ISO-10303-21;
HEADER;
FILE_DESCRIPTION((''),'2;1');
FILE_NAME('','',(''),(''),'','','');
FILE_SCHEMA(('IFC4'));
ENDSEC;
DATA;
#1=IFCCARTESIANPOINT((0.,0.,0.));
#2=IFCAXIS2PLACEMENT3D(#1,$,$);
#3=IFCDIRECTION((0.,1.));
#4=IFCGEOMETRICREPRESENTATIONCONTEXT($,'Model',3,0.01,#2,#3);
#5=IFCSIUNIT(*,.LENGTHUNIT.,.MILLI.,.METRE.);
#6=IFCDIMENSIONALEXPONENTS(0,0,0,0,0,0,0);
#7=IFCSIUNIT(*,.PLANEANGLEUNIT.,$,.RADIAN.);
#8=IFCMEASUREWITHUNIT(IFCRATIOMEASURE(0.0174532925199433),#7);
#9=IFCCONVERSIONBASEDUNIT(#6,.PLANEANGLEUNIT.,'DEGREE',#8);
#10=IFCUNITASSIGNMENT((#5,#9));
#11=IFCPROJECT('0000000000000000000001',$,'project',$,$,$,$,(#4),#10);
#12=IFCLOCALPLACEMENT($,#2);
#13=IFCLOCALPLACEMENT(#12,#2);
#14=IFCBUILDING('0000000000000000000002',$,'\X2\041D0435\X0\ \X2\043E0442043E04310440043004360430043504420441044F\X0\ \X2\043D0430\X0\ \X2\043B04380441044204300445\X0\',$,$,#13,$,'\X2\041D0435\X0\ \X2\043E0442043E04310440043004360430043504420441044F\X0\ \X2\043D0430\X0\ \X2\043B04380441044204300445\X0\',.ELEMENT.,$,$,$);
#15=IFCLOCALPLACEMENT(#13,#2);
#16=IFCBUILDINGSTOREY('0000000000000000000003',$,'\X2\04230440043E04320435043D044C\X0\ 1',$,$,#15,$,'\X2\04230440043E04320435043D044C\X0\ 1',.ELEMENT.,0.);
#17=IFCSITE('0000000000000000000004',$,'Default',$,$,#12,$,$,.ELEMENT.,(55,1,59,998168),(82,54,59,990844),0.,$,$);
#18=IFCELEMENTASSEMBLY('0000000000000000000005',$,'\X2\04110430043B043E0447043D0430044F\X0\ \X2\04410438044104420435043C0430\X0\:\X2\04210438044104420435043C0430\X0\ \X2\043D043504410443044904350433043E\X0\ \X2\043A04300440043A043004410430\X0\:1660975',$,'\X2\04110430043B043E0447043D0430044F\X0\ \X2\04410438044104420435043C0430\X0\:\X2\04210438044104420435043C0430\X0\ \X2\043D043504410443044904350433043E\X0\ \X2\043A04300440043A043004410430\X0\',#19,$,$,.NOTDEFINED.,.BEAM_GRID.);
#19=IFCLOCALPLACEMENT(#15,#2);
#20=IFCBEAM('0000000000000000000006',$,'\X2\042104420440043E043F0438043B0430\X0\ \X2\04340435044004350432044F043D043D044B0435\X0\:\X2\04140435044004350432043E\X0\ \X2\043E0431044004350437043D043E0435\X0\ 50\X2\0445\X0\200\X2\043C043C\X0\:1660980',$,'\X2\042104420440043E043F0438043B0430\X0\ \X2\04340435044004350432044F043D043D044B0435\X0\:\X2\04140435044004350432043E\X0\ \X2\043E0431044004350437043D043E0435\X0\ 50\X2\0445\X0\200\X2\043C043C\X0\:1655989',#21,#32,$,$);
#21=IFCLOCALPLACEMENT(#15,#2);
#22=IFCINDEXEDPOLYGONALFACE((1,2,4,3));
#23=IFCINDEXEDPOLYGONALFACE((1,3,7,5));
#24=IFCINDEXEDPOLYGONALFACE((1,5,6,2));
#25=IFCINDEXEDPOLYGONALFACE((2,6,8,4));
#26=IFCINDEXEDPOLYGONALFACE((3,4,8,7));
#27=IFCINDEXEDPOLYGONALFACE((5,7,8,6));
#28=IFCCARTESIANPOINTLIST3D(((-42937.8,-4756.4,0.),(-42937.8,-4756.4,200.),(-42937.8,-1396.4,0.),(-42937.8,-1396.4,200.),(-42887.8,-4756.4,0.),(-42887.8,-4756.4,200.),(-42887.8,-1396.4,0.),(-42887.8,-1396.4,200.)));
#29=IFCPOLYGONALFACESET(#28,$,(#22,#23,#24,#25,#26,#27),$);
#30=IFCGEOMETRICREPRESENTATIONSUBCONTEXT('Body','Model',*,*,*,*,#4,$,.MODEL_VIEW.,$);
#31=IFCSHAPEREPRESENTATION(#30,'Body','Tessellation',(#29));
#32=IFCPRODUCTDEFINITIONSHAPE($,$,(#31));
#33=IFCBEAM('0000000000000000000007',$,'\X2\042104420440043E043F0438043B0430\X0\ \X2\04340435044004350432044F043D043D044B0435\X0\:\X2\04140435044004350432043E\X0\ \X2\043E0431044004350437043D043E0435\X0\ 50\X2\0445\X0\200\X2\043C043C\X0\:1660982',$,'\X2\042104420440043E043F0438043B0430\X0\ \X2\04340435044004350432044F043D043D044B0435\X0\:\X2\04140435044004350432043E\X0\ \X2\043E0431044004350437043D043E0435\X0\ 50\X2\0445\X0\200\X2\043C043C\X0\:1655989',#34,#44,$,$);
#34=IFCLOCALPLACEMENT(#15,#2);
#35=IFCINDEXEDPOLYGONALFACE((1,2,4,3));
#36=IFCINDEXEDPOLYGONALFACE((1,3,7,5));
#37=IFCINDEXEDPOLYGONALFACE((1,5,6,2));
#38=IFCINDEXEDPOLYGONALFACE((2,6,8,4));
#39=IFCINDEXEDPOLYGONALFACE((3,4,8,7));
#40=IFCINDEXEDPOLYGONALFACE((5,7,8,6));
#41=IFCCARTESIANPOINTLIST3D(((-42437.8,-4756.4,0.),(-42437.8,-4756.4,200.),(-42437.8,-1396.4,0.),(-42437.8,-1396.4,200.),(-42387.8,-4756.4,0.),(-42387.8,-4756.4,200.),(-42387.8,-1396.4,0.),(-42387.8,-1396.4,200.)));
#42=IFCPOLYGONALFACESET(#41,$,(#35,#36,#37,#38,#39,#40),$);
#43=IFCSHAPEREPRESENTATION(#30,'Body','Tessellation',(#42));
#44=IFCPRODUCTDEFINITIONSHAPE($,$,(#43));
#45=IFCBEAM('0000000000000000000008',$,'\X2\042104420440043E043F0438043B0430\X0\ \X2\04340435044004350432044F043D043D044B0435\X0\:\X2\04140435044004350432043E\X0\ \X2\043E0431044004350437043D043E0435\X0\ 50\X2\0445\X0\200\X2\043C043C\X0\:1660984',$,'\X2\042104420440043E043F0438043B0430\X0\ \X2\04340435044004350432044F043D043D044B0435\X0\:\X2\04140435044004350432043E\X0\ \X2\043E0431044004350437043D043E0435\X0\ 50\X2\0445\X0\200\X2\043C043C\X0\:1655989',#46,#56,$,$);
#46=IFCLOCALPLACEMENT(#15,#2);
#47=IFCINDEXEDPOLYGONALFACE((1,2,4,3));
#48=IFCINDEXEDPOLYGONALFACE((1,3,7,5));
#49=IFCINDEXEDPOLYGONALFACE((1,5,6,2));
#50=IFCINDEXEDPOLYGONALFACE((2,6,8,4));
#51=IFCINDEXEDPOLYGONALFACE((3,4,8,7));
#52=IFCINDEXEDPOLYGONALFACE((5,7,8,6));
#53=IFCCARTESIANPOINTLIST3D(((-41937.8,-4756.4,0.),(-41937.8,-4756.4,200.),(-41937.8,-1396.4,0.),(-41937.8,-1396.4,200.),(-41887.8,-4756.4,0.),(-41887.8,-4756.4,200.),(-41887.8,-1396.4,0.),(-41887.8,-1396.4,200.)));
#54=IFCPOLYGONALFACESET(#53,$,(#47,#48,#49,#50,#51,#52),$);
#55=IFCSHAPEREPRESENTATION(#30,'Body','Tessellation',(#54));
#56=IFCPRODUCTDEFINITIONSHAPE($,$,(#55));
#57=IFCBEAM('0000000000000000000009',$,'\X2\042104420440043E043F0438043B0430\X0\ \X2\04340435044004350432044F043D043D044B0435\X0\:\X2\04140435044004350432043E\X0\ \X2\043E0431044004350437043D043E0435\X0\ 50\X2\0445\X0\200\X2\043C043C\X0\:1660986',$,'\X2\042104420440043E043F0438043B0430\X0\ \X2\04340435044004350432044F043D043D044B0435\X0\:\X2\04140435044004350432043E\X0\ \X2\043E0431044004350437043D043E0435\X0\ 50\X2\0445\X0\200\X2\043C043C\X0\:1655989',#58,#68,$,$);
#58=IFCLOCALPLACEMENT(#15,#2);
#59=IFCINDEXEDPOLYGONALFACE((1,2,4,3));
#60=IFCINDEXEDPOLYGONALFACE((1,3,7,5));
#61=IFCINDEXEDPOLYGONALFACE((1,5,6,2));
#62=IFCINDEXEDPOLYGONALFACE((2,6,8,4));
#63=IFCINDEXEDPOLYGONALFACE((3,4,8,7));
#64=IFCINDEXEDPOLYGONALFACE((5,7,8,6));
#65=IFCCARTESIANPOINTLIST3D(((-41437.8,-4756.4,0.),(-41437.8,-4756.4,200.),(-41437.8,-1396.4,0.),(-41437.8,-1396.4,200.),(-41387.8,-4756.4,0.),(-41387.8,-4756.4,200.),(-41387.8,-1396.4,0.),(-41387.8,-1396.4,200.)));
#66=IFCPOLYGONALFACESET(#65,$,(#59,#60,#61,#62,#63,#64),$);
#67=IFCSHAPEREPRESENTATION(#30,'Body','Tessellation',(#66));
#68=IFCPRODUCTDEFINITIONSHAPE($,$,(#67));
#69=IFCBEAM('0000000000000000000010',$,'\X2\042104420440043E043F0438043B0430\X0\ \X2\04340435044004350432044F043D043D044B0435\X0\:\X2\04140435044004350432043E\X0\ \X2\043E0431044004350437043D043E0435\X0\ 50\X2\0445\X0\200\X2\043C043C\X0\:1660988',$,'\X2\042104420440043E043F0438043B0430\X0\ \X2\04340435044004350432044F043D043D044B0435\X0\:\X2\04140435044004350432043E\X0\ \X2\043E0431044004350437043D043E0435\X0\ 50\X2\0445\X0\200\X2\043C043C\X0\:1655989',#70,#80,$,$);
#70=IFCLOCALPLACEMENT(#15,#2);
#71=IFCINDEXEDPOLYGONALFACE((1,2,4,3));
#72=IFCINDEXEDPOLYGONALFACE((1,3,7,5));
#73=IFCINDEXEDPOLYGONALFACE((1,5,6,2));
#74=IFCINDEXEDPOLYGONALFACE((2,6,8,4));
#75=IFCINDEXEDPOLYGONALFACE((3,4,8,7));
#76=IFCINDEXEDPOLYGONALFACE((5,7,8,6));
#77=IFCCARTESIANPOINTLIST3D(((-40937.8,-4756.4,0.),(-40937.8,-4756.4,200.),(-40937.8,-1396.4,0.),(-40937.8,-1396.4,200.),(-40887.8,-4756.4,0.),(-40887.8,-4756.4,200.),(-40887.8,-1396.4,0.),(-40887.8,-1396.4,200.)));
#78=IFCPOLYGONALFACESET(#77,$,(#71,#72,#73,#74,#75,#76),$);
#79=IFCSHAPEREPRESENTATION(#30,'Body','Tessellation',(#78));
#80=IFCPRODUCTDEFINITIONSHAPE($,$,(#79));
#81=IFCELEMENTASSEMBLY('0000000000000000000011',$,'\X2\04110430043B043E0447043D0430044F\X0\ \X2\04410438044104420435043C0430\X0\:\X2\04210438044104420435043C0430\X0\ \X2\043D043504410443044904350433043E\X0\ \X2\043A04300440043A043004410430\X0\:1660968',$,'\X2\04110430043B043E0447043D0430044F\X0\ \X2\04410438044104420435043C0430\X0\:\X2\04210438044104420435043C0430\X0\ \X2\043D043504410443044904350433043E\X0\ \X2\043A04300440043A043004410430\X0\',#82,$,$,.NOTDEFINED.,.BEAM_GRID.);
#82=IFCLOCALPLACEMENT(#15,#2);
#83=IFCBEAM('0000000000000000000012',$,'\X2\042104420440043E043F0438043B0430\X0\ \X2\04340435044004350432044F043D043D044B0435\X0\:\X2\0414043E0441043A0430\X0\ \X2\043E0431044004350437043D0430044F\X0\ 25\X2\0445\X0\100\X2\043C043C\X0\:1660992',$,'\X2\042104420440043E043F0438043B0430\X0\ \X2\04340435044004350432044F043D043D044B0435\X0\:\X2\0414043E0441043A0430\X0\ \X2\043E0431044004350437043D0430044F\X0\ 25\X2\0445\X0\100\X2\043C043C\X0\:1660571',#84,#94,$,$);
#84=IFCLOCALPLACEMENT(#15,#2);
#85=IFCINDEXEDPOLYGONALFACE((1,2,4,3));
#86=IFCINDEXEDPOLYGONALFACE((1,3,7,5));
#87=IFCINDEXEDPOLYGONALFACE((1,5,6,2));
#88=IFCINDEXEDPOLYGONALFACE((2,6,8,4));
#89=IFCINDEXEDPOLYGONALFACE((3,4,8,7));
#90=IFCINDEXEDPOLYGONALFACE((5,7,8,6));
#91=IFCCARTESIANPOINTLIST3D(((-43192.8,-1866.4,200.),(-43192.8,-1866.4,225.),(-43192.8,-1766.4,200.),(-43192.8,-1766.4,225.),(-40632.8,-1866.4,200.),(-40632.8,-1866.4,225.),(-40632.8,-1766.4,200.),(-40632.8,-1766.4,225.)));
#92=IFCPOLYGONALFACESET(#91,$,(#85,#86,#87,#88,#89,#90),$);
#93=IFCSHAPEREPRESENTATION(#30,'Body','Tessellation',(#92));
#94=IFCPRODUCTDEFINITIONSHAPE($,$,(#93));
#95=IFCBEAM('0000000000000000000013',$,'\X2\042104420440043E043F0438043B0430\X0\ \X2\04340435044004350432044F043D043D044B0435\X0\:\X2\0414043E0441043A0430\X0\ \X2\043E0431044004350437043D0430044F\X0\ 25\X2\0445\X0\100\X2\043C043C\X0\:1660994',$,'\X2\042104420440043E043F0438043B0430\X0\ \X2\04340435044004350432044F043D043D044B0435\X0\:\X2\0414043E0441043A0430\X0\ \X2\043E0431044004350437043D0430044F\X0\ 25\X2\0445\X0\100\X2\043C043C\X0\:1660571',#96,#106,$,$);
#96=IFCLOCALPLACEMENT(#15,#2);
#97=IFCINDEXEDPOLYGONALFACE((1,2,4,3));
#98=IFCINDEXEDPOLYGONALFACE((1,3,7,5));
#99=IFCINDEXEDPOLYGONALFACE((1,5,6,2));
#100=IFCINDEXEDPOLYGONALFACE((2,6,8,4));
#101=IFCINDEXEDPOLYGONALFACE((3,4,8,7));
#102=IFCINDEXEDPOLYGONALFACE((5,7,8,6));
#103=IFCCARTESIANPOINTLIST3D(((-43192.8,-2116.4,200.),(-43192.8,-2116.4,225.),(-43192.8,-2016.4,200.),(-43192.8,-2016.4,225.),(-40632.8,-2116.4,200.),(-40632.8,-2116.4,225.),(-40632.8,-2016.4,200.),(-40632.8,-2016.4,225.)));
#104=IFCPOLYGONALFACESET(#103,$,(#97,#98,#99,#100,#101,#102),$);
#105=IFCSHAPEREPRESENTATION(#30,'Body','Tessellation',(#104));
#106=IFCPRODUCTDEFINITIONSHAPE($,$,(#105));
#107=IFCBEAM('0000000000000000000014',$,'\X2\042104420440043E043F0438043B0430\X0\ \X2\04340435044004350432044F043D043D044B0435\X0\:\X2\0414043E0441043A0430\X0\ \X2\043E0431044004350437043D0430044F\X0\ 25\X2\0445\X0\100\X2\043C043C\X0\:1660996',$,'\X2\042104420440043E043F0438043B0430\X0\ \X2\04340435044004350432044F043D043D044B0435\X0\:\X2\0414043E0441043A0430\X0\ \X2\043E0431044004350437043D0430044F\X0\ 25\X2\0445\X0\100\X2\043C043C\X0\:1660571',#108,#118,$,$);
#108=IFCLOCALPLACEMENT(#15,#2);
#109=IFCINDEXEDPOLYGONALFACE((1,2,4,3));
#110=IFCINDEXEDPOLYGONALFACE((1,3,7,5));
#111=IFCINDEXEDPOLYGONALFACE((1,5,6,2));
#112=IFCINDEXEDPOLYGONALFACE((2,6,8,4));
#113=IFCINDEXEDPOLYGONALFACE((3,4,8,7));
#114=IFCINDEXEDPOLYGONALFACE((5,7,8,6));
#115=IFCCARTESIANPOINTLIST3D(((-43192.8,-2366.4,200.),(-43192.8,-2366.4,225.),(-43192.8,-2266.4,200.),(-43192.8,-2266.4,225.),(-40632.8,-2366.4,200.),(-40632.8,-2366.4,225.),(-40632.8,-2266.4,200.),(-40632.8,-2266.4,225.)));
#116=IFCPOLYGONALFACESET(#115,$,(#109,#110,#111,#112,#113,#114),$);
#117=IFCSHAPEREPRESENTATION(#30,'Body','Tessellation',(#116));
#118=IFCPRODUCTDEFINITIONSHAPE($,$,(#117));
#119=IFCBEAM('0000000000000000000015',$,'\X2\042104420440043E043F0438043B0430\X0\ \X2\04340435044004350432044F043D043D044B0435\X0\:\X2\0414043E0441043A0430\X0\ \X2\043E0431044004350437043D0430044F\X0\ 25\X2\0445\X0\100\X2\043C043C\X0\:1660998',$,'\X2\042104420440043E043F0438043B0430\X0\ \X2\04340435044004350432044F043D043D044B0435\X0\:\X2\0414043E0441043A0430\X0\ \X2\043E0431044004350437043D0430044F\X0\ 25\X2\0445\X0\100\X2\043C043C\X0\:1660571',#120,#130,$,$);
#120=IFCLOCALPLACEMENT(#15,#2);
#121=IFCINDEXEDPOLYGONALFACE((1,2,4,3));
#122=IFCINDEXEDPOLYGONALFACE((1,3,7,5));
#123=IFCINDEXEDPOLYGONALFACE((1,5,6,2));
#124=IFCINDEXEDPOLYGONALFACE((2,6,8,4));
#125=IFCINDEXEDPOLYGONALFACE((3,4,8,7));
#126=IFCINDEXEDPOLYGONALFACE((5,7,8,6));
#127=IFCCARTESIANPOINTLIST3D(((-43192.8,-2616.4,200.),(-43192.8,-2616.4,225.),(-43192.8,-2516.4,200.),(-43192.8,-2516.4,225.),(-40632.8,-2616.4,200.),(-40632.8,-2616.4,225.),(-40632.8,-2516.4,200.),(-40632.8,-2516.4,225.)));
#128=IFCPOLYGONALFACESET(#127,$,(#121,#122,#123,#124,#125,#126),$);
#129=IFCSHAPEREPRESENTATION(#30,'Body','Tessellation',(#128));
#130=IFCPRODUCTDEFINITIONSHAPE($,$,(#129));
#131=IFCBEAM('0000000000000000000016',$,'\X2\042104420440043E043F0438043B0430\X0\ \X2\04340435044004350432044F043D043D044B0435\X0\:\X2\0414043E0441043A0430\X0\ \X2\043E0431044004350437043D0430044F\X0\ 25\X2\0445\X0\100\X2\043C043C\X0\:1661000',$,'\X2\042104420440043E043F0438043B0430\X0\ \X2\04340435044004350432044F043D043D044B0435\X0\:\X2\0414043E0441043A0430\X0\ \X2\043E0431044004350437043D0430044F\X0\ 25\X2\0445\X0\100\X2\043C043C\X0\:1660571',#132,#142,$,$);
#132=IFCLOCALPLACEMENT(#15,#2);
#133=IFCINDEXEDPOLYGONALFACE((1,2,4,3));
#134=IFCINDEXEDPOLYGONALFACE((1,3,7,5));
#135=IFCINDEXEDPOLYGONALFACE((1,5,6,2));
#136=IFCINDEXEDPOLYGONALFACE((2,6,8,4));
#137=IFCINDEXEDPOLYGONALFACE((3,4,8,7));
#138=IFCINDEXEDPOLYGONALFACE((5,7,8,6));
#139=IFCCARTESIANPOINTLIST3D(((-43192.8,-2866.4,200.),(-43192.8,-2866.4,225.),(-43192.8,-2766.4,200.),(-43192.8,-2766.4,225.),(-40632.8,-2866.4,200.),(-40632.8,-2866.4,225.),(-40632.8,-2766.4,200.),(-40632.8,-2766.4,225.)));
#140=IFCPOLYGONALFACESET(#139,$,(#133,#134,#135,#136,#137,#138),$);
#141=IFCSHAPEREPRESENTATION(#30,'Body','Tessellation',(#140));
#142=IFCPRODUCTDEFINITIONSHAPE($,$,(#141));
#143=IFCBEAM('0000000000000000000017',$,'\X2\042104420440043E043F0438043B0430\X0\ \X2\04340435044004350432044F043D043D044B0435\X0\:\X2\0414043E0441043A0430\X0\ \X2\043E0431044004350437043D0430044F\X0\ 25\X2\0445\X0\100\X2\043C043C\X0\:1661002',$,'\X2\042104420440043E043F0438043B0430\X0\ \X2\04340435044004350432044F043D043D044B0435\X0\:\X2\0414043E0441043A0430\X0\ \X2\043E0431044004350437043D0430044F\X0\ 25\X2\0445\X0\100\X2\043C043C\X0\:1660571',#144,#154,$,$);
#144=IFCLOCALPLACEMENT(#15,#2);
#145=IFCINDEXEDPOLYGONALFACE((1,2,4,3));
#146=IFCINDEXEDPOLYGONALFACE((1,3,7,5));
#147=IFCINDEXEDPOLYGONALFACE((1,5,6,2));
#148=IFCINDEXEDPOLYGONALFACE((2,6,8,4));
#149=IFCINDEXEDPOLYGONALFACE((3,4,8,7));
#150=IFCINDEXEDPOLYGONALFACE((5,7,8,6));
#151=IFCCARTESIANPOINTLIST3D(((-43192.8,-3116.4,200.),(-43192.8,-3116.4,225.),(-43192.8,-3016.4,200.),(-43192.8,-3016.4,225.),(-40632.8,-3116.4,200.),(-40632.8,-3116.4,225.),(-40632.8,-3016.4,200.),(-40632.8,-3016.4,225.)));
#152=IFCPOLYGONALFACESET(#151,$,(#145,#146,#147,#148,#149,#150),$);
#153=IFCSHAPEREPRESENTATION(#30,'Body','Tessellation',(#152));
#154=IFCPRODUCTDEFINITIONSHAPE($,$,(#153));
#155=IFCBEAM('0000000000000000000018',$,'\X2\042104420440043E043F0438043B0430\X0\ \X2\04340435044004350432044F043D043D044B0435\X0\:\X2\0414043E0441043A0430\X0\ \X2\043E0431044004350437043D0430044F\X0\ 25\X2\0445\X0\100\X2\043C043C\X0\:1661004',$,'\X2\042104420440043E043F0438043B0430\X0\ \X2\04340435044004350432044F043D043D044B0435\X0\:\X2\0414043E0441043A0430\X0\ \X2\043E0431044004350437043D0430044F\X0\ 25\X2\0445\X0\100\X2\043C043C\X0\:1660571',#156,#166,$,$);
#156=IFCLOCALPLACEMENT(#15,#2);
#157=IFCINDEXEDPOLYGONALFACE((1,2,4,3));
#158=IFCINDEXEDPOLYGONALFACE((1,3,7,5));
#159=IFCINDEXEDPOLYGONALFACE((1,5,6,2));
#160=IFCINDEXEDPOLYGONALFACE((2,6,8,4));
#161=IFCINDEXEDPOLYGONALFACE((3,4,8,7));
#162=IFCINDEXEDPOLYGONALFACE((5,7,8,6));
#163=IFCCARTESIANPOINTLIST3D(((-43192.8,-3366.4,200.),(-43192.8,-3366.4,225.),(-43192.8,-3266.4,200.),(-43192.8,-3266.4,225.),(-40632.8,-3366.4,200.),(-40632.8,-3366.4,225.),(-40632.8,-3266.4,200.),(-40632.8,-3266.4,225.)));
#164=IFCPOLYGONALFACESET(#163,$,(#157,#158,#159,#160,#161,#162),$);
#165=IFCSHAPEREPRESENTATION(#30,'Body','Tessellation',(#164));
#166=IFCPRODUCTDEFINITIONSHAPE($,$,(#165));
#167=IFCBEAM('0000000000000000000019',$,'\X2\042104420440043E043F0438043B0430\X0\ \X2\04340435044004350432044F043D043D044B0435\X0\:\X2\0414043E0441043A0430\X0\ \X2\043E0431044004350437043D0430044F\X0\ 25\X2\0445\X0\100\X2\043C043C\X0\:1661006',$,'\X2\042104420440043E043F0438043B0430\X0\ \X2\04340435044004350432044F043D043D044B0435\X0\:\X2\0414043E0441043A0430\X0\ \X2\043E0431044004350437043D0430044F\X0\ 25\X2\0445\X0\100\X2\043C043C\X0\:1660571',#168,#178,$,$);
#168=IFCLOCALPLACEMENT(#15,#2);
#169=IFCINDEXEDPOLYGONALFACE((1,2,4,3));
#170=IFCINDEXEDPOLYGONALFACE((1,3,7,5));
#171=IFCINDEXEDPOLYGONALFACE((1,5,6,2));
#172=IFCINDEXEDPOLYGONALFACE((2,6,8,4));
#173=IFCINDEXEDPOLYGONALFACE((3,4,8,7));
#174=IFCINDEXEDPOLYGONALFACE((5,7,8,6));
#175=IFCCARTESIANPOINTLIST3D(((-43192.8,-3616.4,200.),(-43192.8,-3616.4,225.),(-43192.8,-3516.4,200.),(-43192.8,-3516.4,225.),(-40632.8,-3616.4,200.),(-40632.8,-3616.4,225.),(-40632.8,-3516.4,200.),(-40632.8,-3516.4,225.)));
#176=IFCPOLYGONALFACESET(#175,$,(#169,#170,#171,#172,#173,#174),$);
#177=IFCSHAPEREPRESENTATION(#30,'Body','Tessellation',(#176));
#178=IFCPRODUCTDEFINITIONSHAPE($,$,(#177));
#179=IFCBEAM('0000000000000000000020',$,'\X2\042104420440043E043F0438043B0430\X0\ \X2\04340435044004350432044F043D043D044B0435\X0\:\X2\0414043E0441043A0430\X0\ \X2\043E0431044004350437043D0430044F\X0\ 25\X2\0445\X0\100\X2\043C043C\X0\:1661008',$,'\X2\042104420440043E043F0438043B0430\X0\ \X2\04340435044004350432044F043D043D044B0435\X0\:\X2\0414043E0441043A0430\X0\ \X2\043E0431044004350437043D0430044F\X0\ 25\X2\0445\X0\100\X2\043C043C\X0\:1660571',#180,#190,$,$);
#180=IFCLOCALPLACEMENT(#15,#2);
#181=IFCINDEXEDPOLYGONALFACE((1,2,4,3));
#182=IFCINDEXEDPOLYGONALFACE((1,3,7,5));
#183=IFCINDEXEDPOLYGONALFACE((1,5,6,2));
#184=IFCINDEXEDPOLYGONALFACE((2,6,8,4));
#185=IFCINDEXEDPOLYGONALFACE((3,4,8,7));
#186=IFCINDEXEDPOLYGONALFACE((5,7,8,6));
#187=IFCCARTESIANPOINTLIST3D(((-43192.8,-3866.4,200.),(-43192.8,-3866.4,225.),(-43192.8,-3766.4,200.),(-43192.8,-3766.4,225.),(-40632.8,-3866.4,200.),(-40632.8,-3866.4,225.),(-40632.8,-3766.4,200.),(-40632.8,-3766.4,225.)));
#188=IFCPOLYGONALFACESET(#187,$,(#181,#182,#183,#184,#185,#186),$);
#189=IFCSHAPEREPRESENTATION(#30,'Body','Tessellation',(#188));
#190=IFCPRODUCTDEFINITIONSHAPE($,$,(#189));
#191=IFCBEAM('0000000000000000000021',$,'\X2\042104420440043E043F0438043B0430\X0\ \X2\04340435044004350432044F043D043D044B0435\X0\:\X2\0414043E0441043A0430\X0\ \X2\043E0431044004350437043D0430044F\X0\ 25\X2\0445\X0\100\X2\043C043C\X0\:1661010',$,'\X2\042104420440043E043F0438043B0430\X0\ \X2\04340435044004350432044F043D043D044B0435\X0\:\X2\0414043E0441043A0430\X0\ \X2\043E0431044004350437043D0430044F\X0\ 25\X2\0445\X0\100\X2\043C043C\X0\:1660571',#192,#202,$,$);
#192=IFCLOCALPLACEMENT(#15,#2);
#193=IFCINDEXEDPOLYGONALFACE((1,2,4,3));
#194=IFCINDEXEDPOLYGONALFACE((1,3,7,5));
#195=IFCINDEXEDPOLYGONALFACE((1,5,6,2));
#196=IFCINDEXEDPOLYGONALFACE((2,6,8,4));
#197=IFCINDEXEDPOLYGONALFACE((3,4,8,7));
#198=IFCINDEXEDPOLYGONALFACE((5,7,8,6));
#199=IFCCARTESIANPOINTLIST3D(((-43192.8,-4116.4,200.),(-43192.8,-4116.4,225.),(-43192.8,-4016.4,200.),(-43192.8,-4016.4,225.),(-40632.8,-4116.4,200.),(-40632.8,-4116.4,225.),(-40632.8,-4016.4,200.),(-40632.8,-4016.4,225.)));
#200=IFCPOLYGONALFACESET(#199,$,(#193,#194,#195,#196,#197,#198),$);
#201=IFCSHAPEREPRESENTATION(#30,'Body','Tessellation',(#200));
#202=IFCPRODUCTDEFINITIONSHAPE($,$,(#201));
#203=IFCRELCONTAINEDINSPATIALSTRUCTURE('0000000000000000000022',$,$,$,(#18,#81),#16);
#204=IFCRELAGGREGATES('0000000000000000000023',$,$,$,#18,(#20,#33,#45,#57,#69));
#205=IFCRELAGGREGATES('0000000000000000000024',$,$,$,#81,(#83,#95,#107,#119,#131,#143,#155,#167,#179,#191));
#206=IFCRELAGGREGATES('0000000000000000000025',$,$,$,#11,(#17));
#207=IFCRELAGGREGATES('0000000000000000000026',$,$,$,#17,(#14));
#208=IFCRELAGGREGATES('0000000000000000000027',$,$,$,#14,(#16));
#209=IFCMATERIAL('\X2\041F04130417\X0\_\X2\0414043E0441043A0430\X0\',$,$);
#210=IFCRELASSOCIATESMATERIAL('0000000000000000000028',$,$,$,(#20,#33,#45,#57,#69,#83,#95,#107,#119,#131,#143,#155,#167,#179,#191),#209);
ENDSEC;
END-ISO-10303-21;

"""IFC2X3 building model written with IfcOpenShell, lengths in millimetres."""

from ifc_helpers import new_model, entity, si_unit, converted_unit, direction, frame, frame_2d, origin, origin_2d_with_axis, place, context, subcontext, project, spatial, rectangle, extrude, material, element, aggregate, save


model = new_model("IFC2X3")

# Units and contexts
model_context = context("Model", 3, precision=0.01, world=origin(), true_north=direction((0.0, 1.0)))
body_context = subcontext(model_context, "Body", "Model", "MODEL_VIEW")
ifc_project = project(units=[si_unit("LENGTHUNIT", "METRE", prefix="MILLI"), converted_unit("PLANEANGLEUNIT", "DEGREE", entity("IfcRatioMeasure", 0.0174532925199433), si_unit("PLANEANGLEUNIT", "RADIAN"), dimensions=[0, 0, 0, 0, 0, 0, 0])], contexts=[model_context])

# Site, building, storey
site_placement = place(None, origin())
site = spatial("IfcSite", under=ifc_project, at=site_placement, Name="Default", CompositionType="ELEMENT", RefLatitude=(55, 1, 59, 998168), RefLongitude=(82, 54, 59, 990844), RefElevation=0.0)
building_placement = place(site_placement, origin())
building = spatial("IfcBuilding", under=site, at=building_placement, Name="Не отображается на листах", LongName="Не отображается на листах", CompositionType="ELEMENT")
storey_placement = place(building_placement, frame((0.0, 0.0, 0.0)))
storey = spatial("IfcBuildingStorey", under=building, at=storey_placement, Name="Уровень 1", LongName="Уровень 1", CompositionType="ELEMENT", Elevation=0.0)

# Element assemblies, beams
assembly_1_placement = place(storey_placement, origin())
assembly_1 = element("IfcElementAssembly", 1, at=assembly_1_placement, inside=storey, Name="Балочная система:Система несущего каркаса:1660975", ObjectType="Балочная система:Система несущего каркаса", AssemblyPlace="NOTDEFINED", PredefinedType="BEAM_GRID")
ifc_material_1 = material(Name="ПГЗ_Доска")
beam_1_placement = place(assembly_1_placement, frame((-42912.8, -4756.4, 0.0), z_axis=(0.0, 0.0, 1.0), x_axis=(0.0, 1.0, 0.0)))
beam_1 = element("IfcBeam", 2, at=beam_1_placement, material=ifc_material_1, Name="Стропила деревянные:Дерево обрезное 50х200мм:1660980", ObjectType="Стропила деревянные:Дерево обрезное 50х200мм:1655989", context=body_context, shape_type="SweptSolid", body=[
    extrude(rectangle(XDim=200.0, YDim=50.0, at=frame_2d((0.0, 0.0), x_axis=(1.0, 0.0))), frame((0.0, 0.0, 100.0), z_axis=(1.0, 0.0, 0.0), x_axis=(0.0, 0.0, -1.0)), (0.0, 0.0, 1.0), 3360.0),
])
beam_2_placement = place(assembly_1_placement, frame((-42412.8, -4756.4, 0.0), z_axis=(0.0, 0.0, 1.0), x_axis=(0.0, 1.0, 0.0)))
beam_2 = element("IfcBeam", 3, at=beam_2_placement, material=ifc_material_1, Name="Стропила деревянные:Дерево обрезное 50х200мм:1660982", ObjectType="Стропила деревянные:Дерево обрезное 50х200мм:1655989", context=body_context, shape_type="SweptSolid", body=[
    extrude(rectangle(XDim=200.0, YDim=50.0, at=frame_2d((0.0, 0.0), x_axis=(1.0, 0.0))), frame((0.0, 0.0, 100.0), z_axis=(1.0, 0.0, 0.0), x_axis=(0.0, 0.0, -1.0)), (0.0, 0.0, 1.0), 3360.0),
])
beam_3_placement = place(assembly_1_placement, frame((-41912.8, -4756.4, 0.0), z_axis=(0.0, 0.0, 1.0), x_axis=(0.0, 1.0, 0.0)))
beam_3 = element("IfcBeam", 4, at=beam_3_placement, material=ifc_material_1, Name="Стропила деревянные:Дерево обрезное 50х200мм:1660984", ObjectType="Стропила деревянные:Дерево обрезное 50х200мм:1655989", context=body_context, shape_type="SweptSolid", body=[
    extrude(rectangle(XDim=200.0, YDim=50.0, at=frame_2d((0.0, 0.0), x_axis=(1.0, 0.0))), frame((0.0, 0.0, 100.0), z_axis=(1.0, 0.0, 0.0), x_axis=(0.0, 0.0, -1.0)), (0.0, 0.0, 1.0), 3360.0),
])
beam_4_placement = place(assembly_1_placement, frame((-41412.8, -4756.4, 0.0), z_axis=(0.0, 0.0, 1.0), x_axis=(0.0, 1.0, 0.0)))
beam_4 = element("IfcBeam", 5, at=beam_4_placement, material=ifc_material_1, Name="Стропила деревянные:Дерево обрезное 50х200мм:1660986", ObjectType="Стропила деревянные:Дерево обрезное 50х200мм:1655989", context=body_context, shape_type="SweptSolid", body=[
    extrude(rectangle(XDim=200.0, YDim=50.0, at=frame_2d((0.0, 0.0), x_axis=(1.0, 0.0))), frame((0.0, 0.0, 100.0), z_axis=(1.0, 0.0, 0.0), x_axis=(0.0, 0.0, -1.0)), (0.0, 0.0, 1.0), 3360.0),
])
beam_5_placement = place(assembly_1_placement, frame((-40912.8, -4756.4, 0.0), z_axis=(0.0, 0.0, 1.0), x_axis=(0.0, 1.0, 0.0)))
beam_5 = element("IfcBeam", 6, at=beam_5_placement, material=ifc_material_1, Name="Стропила деревянные:Дерево обрезное 50х200мм:1660988", ObjectType="Стропила деревянные:Дерево обрезное 50х200мм:1655989", context=body_context, shape_type="SweptSolid", body=[
    extrude(rectangle(XDim=200.0, YDim=50.0, at=frame_2d((0.0, 0.0), x_axis=(1.0, 0.0))), frame((0.0, 0.0, 100.0), z_axis=(1.0, 0.0, 0.0), x_axis=(0.0, 0.0, -1.0)), (0.0, 0.0, 1.0), 3360.0),
])
aggregate(assembly_1, [beam_1, beam_2, beam_3, beam_4, beam_5])
assembly_2_placement = place(storey_placement, origin())
assembly_2 = element("IfcElementAssembly", 7, at=assembly_2_placement, inside=storey, Name="Балочная система:Система несущего каркаса:1660968", ObjectType="Балочная система:Система несущего каркаса", AssemblyPlace="NOTDEFINED", PredefinedType="BEAM_GRID")
beam_6_placement = place(assembly_2_placement, frame((-43192.8, -1816.4, 0.0)))
beam_6 = element("IfcBeam", 8, at=beam_6_placement, material=ifc_material_1, Name="Стропила деревянные:Доска обрезная 25х100мм:1660992", ObjectType="Стропила деревянные:Доска обрезная 25х100мм:1660571", context=body_context, shape_type="SweptSolid", body=[
    extrude(rectangle(XDim=25.0, YDim=100.0, at=origin_2d_with_axis()), frame((0.0, 0.0, 212.5), z_axis=(1.0, 0.0, 0.0), x_axis=(0.0, 0.0, -1.0)), (0.0, 0.0, 1.0), 2560.0),
])
beam_7_placement = place(assembly_2_placement, frame((-43192.8, -2066.4, 0.0)))
beam_7 = element("IfcBeam", 9, at=beam_7_placement, material=ifc_material_1, Name="Стропила деревянные:Доска обрезная 25х100мм:1660994", ObjectType="Стропила деревянные:Доска обрезная 25х100мм:1660571", context=body_context, shape_type="SweptSolid", body=[
    extrude(rectangle(XDim=25.0, YDim=100.0, at=origin_2d_with_axis()), frame((0.0, 0.0, 212.5), z_axis=(1.0, 0.0, 0.0), x_axis=(0.0, 0.0, -1.0)), (0.0, 0.0, 1.0), 2560.0),
])
beam_8_placement = place(assembly_2_placement, frame((-43192.8, -2316.4, 0.0)))
beam_8 = element("IfcBeam", 10, at=beam_8_placement, material=ifc_material_1, Name="Стропила деревянные:Доска обрезная 25х100мм:1660996", ObjectType="Стропила деревянные:Доска обрезная 25х100мм:1660571", context=body_context, shape_type="SweptSolid", body=[
    extrude(rectangle(XDim=25.0, YDim=100.0, at=origin_2d_with_axis()), frame((0.0, 0.0, 212.5), z_axis=(1.0, 0.0, 0.0), x_axis=(0.0, 0.0, -1.0)), (0.0, 0.0, 1.0), 2560.0),
])
beam_9_placement = place(assembly_2_placement, frame((-43192.8, -2566.4, 0.0)))
beam_9 = element("IfcBeam", 11, at=beam_9_placement, material=ifc_material_1, Name="Стропила деревянные:Доска обрезная 25х100мм:1660998", ObjectType="Стропила деревянные:Доска обрезная 25х100мм:1660571", context=body_context, shape_type="SweptSolid", body=[
    extrude(rectangle(XDim=25.0, YDim=100.0, at=origin_2d_with_axis()), frame((0.0, 0.0, 212.5), z_axis=(1.0, 0.0, 0.0), x_axis=(0.0, 0.0, -1.0)), (0.0, 0.0, 1.0), 2560.0),
])
beam_10_placement = place(assembly_2_placement, frame((-43192.8, -2816.4, 0.0)))
beam_10 = element("IfcBeam", 12, at=beam_10_placement, material=ifc_material_1, Name="Стропила деревянные:Доска обрезная 25х100мм:1661000", ObjectType="Стропила деревянные:Доска обрезная 25х100мм:1660571", context=body_context, shape_type="SweptSolid", body=[
    extrude(rectangle(XDim=25.0, YDim=100.0, at=origin_2d_with_axis()), frame((0.0, 0.0, 212.5), z_axis=(1.0, 0.0, 0.0), x_axis=(0.0, 0.0, -1.0)), (0.0, 0.0, 1.0), 2560.0),
])
beam_11_placement = place(assembly_2_placement, frame((-43192.8, -3066.4, 0.0)))
beam_11 = element("IfcBeam", 13, at=beam_11_placement, material=ifc_material_1, Name="Стропила деревянные:Доска обрезная 25х100мм:1661002", ObjectType="Стропила деревянные:Доска обрезная 25х100мм:1660571", context=body_context, shape_type="SweptSolid", body=[
    extrude(rectangle(XDim=25.0, YDim=100.0, at=origin_2d_with_axis()), frame((0.0, 0.0, 212.5), z_axis=(1.0, 0.0, 0.0), x_axis=(0.0, 0.0, -1.0)), (0.0, 0.0, 1.0), 2560.0),
])
beam_12_placement = place(assembly_2_placement, frame((-43192.8, -3316.4, 0.0)))
beam_12 = element("IfcBeam", 14, at=beam_12_placement, material=ifc_material_1, Name="Стропила деревянные:Доска обрезная 25х100мм:1661004", ObjectType="Стропила деревянные:Доска обрезная 25х100мм:1660571", context=body_context, shape_type="SweptSolid", body=[
    extrude(rectangle(XDim=25.0, YDim=100.0, at=origin_2d_with_axis()), frame((0.0, 0.0, 212.5), z_axis=(1.0, 0.0, 0.0), x_axis=(0.0, 0.0, -1.0)), (0.0, 0.0, 1.0), 2560.0),
])
beam_13_placement = place(assembly_2_placement, frame((-43192.8, -3566.4, 0.0)))
beam_13 = element("IfcBeam", 15, at=beam_13_placement, material=ifc_material_1, Name="Стропила деревянные:Доска обрезная 25х100мм:1661006", ObjectType="Стропила деревянные:Доска обрезная 25х100мм:1660571", context=body_context, shape_type="SweptSolid", body=[
    extrude(rectangle(XDim=25.0, YDim=100.0, at=origin_2d_with_axis()), frame((0.0, 0.0, 212.5), z_axis=(1.0, 0.0, 0.0), x_axis=(0.0, 0.0, -1.0)), (0.0, 0.0, 1.0), 2560.0),
])
beam_14_placement = place(assembly_2_placement, frame((-43192.8, -3816.4, 0.0)))
beam_14 = element("IfcBeam", 16, at=beam_14_placement, material=ifc_material_1, Name="Стропила деревянные:Доска обрезная 25х100мм:1661008", ObjectType="Стропила деревянные:Доска обрезная 25х100мм:1660571", context=body_context, shape_type="SweptSolid", body=[
    extrude(rectangle(XDim=25.0, YDim=100.0, at=origin_2d_with_axis()), frame((0.0, 0.0, 212.5), z_axis=(1.0, 0.0, 0.0), x_axis=(0.0, 0.0, -1.0)), (0.0, 0.0, 1.0), 2560.0),
])
beam_15_placement = place(assembly_2_placement, frame((-43192.8, -4066.4, 0.0)))
beam_15 = element("IfcBeam", 17, at=beam_15_placement, material=ifc_material_1, Name="Стропила деревянные:Доска обрезная 25х100мм:1661010", ObjectType="Стропила деревянные:Доска обрезная 25х100мм:1660571", context=body_context, shape_type="SweptSolid", body=[
    extrude(rectangle(XDim=25.0, YDim=100.0, at=origin_2d_with_axis()), frame((0.0, 0.0, 212.5), z_axis=(1.0, 0.0, 0.0), x_axis=(0.0, 0.0, -1.0)), (0.0, 0.0, 1.0), 2560.0),
])
aggregate(assembly_2, [beam_6, beam_7, beam_8, beam_9, beam_10, beam_11, beam_12, beam_13, beam_14, beam_15])

save(model, "model.ifc")
